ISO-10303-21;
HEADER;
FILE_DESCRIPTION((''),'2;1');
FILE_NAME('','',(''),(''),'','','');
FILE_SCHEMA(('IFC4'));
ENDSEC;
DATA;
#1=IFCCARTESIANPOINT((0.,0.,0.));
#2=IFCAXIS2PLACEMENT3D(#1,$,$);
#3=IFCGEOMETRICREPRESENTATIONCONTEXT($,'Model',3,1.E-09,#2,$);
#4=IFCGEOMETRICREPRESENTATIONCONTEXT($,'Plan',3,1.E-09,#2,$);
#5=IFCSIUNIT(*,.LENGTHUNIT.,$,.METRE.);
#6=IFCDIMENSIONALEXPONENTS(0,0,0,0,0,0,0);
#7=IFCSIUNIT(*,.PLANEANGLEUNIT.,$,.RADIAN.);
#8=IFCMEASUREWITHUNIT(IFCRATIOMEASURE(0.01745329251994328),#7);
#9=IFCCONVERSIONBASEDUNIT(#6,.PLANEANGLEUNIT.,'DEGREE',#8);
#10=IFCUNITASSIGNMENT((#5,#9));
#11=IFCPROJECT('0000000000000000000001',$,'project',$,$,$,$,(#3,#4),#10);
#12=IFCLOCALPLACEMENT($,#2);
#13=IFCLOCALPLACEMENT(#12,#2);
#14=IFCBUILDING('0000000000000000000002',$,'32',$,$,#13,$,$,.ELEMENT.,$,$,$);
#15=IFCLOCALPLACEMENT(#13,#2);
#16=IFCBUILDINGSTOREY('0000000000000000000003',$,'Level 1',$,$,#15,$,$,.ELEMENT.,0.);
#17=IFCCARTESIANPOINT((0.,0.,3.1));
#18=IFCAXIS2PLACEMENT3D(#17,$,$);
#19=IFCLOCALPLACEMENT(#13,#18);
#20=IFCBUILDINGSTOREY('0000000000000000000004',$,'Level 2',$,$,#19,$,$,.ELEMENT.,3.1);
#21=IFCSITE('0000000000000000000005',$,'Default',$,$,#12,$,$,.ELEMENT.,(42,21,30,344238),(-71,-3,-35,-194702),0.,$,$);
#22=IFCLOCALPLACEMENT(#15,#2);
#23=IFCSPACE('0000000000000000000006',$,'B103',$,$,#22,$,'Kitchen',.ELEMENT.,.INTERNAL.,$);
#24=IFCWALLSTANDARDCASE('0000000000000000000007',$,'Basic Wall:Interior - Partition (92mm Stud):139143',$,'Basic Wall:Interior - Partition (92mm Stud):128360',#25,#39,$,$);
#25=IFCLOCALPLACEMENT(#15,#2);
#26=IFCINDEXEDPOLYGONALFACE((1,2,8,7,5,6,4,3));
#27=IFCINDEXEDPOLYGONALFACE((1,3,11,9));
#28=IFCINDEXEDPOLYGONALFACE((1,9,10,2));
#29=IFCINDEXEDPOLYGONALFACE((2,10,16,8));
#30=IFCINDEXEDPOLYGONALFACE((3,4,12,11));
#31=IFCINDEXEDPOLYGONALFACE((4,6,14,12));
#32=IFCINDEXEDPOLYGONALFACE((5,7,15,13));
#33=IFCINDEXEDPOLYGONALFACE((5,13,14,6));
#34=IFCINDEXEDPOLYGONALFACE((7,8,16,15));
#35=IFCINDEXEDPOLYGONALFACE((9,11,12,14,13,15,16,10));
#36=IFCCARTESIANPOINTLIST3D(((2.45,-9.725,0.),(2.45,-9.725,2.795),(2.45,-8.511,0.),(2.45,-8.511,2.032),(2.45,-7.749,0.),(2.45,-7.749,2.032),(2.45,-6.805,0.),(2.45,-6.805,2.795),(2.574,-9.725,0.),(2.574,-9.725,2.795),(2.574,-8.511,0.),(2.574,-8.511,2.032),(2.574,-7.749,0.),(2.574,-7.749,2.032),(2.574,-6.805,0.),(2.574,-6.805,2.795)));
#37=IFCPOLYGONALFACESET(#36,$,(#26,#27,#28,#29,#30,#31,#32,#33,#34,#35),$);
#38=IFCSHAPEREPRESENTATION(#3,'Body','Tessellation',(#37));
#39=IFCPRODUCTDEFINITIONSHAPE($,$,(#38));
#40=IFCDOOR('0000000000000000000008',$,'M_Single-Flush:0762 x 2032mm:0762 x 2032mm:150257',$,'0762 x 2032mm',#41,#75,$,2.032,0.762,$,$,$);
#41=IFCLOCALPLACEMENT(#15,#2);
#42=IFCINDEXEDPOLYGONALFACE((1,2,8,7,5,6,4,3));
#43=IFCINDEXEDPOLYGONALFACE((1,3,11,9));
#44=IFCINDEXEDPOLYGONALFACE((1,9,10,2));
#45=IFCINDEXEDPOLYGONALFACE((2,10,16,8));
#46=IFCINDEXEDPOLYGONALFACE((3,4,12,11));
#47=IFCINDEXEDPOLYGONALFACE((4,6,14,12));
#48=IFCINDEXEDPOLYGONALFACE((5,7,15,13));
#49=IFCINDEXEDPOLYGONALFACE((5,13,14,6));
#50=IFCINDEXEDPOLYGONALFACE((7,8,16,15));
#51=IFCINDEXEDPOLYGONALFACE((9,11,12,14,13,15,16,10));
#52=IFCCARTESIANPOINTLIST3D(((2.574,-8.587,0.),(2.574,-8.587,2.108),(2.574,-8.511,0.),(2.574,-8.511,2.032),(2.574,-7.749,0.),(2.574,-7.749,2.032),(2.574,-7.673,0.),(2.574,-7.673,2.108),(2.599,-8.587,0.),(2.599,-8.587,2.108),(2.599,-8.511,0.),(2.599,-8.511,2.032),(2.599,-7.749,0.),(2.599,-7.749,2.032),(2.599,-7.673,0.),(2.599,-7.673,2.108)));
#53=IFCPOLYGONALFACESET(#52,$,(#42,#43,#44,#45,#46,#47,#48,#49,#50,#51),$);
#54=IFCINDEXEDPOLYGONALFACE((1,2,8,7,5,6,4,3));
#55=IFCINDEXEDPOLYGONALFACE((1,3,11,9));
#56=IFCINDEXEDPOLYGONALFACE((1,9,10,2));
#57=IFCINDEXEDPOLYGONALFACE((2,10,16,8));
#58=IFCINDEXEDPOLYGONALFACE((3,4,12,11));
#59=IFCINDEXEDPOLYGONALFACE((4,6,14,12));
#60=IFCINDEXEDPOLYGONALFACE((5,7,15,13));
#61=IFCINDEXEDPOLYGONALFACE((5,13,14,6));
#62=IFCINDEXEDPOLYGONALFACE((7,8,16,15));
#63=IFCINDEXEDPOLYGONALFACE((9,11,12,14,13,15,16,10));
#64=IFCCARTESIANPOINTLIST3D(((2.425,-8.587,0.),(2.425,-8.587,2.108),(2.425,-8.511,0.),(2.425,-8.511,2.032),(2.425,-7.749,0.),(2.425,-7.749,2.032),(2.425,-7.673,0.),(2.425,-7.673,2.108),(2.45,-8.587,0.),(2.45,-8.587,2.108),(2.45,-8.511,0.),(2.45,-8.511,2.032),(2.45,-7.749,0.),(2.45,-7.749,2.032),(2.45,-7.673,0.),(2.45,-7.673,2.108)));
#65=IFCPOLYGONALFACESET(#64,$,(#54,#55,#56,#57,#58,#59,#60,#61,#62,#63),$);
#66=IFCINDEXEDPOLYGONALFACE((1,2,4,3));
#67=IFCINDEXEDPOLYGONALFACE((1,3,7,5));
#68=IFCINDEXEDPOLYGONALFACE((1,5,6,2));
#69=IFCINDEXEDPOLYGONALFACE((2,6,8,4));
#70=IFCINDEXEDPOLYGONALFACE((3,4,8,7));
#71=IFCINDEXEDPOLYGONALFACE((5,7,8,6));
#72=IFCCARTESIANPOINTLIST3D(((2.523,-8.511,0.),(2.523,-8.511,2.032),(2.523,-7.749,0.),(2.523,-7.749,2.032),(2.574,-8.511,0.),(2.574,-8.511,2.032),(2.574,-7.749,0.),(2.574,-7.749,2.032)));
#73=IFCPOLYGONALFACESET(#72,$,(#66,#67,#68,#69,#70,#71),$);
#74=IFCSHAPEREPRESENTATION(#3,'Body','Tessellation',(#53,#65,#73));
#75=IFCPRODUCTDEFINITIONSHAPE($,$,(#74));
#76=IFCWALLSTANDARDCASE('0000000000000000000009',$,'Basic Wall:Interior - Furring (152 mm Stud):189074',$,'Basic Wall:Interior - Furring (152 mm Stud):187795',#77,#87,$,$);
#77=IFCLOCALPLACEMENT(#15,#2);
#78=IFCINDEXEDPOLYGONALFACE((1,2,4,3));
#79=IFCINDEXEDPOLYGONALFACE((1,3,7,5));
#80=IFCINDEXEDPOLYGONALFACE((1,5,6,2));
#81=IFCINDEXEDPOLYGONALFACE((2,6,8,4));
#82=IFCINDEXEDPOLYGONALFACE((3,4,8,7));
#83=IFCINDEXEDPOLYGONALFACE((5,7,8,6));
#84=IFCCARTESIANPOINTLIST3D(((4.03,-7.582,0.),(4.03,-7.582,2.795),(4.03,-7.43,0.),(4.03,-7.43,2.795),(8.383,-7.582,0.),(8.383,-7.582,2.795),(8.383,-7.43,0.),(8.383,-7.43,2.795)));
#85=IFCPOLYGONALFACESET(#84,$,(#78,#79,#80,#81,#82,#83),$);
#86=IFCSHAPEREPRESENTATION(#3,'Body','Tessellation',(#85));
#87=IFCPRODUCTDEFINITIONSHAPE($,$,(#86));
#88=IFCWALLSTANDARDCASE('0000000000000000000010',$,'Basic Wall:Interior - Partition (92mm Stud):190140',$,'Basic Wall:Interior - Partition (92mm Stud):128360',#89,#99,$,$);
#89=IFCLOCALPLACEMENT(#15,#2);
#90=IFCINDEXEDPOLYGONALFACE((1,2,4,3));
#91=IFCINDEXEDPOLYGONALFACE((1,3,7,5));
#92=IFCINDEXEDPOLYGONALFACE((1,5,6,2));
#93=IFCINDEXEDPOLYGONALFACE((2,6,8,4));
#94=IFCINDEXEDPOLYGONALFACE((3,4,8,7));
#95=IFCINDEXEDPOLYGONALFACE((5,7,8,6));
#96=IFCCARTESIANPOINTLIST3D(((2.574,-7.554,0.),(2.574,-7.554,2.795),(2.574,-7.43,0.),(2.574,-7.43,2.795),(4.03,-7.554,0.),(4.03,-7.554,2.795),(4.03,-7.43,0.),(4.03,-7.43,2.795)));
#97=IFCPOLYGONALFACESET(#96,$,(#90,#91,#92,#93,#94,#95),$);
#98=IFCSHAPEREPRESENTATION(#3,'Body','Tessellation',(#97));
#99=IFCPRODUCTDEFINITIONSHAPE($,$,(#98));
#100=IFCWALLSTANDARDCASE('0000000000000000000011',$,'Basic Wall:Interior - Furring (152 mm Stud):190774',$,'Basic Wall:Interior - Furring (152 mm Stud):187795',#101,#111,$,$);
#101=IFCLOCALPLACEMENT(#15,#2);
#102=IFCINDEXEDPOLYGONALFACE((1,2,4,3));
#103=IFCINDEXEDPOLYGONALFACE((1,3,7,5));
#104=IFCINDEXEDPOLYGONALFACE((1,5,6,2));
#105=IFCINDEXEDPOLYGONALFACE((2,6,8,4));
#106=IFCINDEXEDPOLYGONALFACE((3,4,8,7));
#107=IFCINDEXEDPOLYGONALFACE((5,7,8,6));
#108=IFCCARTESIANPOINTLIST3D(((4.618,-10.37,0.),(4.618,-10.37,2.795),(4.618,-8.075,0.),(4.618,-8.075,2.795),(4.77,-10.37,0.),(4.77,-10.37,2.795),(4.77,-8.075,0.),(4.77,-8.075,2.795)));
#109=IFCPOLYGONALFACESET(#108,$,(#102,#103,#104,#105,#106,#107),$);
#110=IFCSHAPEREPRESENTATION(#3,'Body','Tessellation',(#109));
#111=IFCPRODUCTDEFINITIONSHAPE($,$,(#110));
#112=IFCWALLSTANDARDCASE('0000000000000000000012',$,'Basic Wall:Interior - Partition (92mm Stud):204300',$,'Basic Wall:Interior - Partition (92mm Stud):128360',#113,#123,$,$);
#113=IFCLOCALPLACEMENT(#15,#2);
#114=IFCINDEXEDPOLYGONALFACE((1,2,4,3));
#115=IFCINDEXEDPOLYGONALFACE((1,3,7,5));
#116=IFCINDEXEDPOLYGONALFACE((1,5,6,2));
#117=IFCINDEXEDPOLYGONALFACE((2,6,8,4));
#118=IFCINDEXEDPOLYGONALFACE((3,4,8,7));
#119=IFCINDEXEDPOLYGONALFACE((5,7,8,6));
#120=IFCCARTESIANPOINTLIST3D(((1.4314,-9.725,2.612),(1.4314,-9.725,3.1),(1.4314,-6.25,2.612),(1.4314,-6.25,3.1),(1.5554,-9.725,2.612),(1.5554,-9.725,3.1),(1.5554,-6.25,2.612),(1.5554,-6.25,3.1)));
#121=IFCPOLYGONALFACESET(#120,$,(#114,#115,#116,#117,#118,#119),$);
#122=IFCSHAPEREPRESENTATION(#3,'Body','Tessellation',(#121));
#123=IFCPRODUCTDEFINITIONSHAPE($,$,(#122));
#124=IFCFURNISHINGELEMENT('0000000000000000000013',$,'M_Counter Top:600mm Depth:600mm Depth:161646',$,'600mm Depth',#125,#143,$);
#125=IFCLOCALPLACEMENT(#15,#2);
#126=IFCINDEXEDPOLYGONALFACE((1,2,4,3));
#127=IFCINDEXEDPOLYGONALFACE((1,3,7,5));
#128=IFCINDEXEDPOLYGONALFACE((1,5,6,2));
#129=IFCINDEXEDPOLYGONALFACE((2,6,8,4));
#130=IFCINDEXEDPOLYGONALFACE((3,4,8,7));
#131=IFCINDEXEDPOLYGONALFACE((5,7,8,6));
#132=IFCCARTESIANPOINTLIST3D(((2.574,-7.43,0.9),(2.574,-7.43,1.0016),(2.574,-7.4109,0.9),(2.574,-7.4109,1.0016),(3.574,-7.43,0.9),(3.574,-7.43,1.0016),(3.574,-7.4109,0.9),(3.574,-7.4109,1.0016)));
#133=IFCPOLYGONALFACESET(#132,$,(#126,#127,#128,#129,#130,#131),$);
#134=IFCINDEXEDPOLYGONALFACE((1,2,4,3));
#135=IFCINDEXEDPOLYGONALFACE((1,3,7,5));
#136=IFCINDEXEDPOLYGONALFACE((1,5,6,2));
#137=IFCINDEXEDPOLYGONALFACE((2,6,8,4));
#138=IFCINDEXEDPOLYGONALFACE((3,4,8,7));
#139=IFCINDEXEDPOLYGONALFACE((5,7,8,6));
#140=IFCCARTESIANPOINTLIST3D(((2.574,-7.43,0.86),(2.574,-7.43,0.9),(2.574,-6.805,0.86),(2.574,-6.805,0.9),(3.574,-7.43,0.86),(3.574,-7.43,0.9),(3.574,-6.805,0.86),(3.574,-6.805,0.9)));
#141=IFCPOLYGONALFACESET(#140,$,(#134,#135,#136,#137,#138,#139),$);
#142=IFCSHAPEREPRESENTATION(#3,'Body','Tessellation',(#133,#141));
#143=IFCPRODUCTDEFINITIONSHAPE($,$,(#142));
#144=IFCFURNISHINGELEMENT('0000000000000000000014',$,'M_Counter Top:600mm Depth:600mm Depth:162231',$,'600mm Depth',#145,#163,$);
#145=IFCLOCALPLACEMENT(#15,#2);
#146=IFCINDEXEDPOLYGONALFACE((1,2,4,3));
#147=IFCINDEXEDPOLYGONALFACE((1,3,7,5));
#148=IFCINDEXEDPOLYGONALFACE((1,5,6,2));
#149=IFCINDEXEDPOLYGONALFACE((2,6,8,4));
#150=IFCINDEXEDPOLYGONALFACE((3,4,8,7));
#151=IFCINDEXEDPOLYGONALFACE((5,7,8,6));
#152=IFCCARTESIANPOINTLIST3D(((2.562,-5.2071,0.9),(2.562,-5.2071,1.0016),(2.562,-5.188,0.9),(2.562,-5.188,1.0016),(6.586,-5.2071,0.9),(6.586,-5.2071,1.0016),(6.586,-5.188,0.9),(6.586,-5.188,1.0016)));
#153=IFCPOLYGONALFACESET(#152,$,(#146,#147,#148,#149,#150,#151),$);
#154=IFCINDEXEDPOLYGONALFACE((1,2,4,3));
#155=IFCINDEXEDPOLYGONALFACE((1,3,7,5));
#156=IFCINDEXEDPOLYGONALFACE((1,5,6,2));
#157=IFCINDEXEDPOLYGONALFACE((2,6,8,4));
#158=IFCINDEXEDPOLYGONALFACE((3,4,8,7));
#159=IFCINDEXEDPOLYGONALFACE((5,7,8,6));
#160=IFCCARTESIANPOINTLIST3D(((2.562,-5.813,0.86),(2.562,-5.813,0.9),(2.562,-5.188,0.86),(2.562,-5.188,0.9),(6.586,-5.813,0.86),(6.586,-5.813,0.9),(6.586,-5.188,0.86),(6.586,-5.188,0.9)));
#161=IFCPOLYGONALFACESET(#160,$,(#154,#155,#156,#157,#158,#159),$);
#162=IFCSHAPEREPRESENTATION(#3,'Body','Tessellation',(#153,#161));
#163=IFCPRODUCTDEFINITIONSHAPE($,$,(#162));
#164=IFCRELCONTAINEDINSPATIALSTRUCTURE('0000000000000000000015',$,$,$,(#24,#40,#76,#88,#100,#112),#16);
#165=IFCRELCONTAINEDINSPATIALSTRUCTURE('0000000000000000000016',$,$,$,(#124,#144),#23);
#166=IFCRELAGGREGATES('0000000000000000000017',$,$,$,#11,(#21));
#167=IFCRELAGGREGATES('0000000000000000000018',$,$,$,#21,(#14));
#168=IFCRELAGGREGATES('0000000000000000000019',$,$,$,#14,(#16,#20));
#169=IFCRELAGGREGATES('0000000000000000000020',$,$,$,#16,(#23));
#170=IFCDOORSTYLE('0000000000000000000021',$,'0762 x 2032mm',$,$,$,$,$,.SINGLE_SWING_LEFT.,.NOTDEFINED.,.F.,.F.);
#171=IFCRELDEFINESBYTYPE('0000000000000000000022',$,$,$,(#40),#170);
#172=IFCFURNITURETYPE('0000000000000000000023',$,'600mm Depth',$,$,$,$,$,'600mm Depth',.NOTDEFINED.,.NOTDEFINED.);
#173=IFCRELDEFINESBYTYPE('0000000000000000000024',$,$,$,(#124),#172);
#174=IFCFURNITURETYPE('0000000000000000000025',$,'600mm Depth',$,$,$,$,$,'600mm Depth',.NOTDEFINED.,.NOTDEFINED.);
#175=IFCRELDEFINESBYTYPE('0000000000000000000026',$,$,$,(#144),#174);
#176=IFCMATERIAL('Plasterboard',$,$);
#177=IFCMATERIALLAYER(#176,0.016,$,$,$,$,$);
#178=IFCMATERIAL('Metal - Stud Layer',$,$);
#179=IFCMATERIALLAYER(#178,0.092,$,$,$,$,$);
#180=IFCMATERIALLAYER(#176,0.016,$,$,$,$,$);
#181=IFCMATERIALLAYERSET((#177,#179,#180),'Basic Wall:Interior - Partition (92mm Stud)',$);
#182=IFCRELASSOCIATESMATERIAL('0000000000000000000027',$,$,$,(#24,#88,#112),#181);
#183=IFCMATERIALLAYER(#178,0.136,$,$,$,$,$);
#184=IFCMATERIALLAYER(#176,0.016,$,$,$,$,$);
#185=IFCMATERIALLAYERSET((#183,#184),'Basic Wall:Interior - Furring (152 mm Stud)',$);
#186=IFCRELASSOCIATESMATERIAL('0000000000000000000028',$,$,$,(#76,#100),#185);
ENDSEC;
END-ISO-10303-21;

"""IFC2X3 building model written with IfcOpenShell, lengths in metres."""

from ifc_helpers import new_model, entity, si_unit, converted_unit, frame, frame_2d, origin, origin_2d_with_axis, place, context, project, spatial, polyline, rectangle, outline, extrude, clip, bounded_halfspace, source, transform, mapped, material, layer, layer_set, layer_usage, type_object, type_shapes, element, fill, save


model = new_model("IFC2X3")

# Units and contexts
model_context = context("Model", 3, precision=1e-09, world=origin())
plan_context = context("Plan", 3, precision=1e-09, world=origin())
ifc_project = project(units=[si_unit("LENGTHUNIT", "METRE"), converted_unit("PLANEANGLEUNIT", "DEGREE", entity("IfcRatioMeasure", 0.01745329251994328), si_unit("PLANEANGLEUNIT", "RADIAN"), dimensions=[0, 0, 0, 0, 0, 0, 0])], contexts=[model_context, plan_context])

# Site, building, storey
site_placement = place(None, origin())
site = spatial("IfcSite", under=ifc_project, at=site_placement, Name="Default", CompositionType="ELEMENT", RefLatitude=(42, 21, 30, 344238), RefLongitude=(-71, -3, -35, -194702), RefElevation=0.0)
building_placement = place(site_placement, origin())
building = spatial("IfcBuilding", under=site, at=building_placement, Name="32", CompositionType="ELEMENT")
storey_1_placement = place(building_placement, origin())
storey_1 = spatial("IfcBuildingStorey", under=building, at=storey_1_placement, Name="Level 1", CompositionType="ELEMENT", Elevation=0.0)

# Shared definitions
ifc_material_1 = material(Name="Metal - Stud Layer")
ifc_material_2 = material(Name="Plasterboard")

# Shared definitions
ifc_layer_1 = layer(ifc_material_2, 0.016)
ifc_layer_2 = layer(ifc_material_1, 0.092)
ifc_layer_3 = layer(ifc_material_2, 0.016)
ifc_layer_set_1 = layer_set([ifc_layer_1, ifc_layer_2, ifc_layer_3], Name="Basic Wall:Interior - Partition (92mm Stud)")

# Wall, opening, door
ifc_layer_usage_1 = layer_usage(ifc_layer_set_1, "AXIS2", "NEGATIVE", 0.062)
wall_1_placement = place(storey_1_placement, frame((2.512, -6.805, 0.0), z_axis=(0.0, 0.0, 1.0), x_axis=(0.0, -1.0, 0.0)))
wall_1 = element("IfcWallStandardCase", 1, at=wall_1_placement, inside=storey_1, material=ifc_layer_usage_1, Name="Basic Wall:Interior - Partition (92mm Stud):139143", ObjectType="Basic Wall:Interior - Partition (92mm Stud):128360", context=model_context, shape_type="SweptSolid", body=[
    extrude(rectangle(XDim=2.92, YDim=0.124, at=frame_2d((1.46, 0.0), x_axis=(-1.0, 0.0))), origin(), (0.0, 0.0, 1.0), 2.795),
])
opening_1_placement = place(wall_1_placement, frame((0.944, -0.062, 0.0)))
opening_1 = element("IfcOpeningElement", 2, at=opening_1_placement, cuts=wall_1, ObjectType="Opening", context=model_context, shape_type="SweptSolid", body=[
    extrude(rectangle(XDim=0.762, YDim=2.032, at=frame_2d((1.016, 0.381), x_axis=(0.0, -1.0))), frame((0.0, 0.0, 0.0), z_axis=(0.0, 1.0, 0.0), x_axis=(0.0, 0.0, 1.0)), (0.0, 0.0, 1.0), 0.124),
])
door_style_1 = type_object("IfcDoorStyle", Name="0762 x 2032mm", ConstructionType="NOTDEFINED", OperationType="SINGLE_SWING_LEFT", ParameterTakesPrecedence=False, Sizeable=False)
shared_shape_1 = source(origin(), model_context, "Body", "SweptSolid", [
    extrude(outline(polyline([(-0.457, -1.073), (0.457, -1.073), (0.457, 1.035), (0.381, 1.035), (0.381, -0.997), (-0.381, -0.997), (-0.381, 1.035), (-0.457, 1.035), (-0.457, -1.073)])), frame((0.381, 0.149, 1.035), z_axis=(0.0, -1.0, 0.0), x_axis=(-1.0, 0.0, 0.0)), (0.0, 0.0, 1.0), 0.025),
    extrude(outline(polyline([(-1.073, -0.457), (1.035, -0.457), (1.035, -0.381), (-0.997, -0.381), (-0.997, 0.381), (1.035, 0.381), (1.035, 0.457), (-1.073, 0.457), (-1.073, -0.457)])), frame((0.381, 0.0, 1.035), z_axis=(0.0, -1.0, 0.0), x_axis=(0.0, 0.0, -1.0)), (0.0, 0.0, 1.0), 0.025),
    extrude(rectangle(XDim=0.762, YDim=0.051, at=origin_2d_with_axis()), frame((0.381, 0.0985, 0.0)), (0.0, 0.0, 1.0), 2.032),
])
type_shapes(door_style_1, [shared_shape_1])
door_1_placement = place(opening_1_placement, origin())
door_1 = element("IfcDoor", 3, at=door_1_placement, inside=storey_1, type_object=door_style_1, Name="M_Single-Flush:0762 x 2032mm:0762 x 2032mm:150257", ObjectType="0762 x 2032mm", OverallHeight=2.032, OverallWidth=0.762, context=model_context, shape_type="MappedRepresentation", body=[
    mapped(shared_shape_1, transform((0.0, 0.0, 0.0), scale=1.0)),
])
fill(opening_1, door_1)

# Shared definitions
storey_2_placement = place(building_placement, frame((0.0, 0.0, 3.1)))
storey_2 = spatial("IfcBuildingStorey", under=building, at=storey_2_placement, Name="Level 2", CompositionType="ELEMENT", Elevation=3.1)

# Walls
ifc_layer_4 = layer(ifc_material_1, 0.136)
ifc_layer_5 = layer(ifc_material_2, 0.016)
ifc_layer_set_2 = layer_set([ifc_layer_4, ifc_layer_5], Name="Basic Wall:Interior - Furring (152 mm Stud)")
ifc_layer_usage_2 = layer_usage(ifc_layer_set_2, "AXIS2", "NEGATIVE", 0.076)
wall_2_placement = place(storey_1_placement, frame((8.383, -7.506, 0.0), z_axis=(0.0, 0.0, 1.0), x_axis=(-1.0, 0.0, 0.0)))
element("IfcWallStandardCase", 4, at=wall_2_placement, inside=storey_1, material=ifc_layer_usage_2, Name="Basic Wall:Interior - Furring (152 mm Stud):189074", ObjectType="Basic Wall:Interior - Furring (152 mm Stud):187795", context=model_context, shape_type="Clipping", body=[
    clip(extrude(rectangle(XDim=4.353, YDim=0.152, at=frame_2d((2.1765, 0.0), x_axis=(-1.0, 0.0))), origin(), (0.0, 0.0, 1.0), 2.795), bounded_halfspace(frame((0.0, -0.076, 2.795), z_axis=(0.0, 0.0, -1.0), x_axis=(0.0, 1.0, 0.0)), True, frame((0.0, -0.076, 2.795)), polyline([(0.0, 0.0), (3.708, 0.0), (3.708, 0.152), (0.0, 0.152), (0.0, 0.0)]))),
])
ifc_layer_usage_3 = layer_usage(ifc_layer_set_1, "AXIS2", "NEGATIVE", 0.062)
wall_3_placement = place(storey_1_placement, frame((4.03, -7.492, 0.0), z_axis=(0.0, 0.0, 1.0), x_axis=(-1.0, 0.0, 0.0)))
element("IfcWallStandardCase", 5, at=wall_3_placement, inside=storey_1, material=ifc_layer_usage_3, Name="Basic Wall:Interior - Partition (92mm Stud):190140", ObjectType="Basic Wall:Interior - Partition (92mm Stud):128360", context=model_context, shape_type="SweptSolid", body=[
    extrude(rectangle(XDim=1.456, YDim=0.124, at=frame_2d((0.728, 0.0), x_axis=(-1.0, 0.0))), origin(), (0.0, 0.0, 1.0), 2.795),
])
ifc_layer_usage_4 = layer_usage(ifc_layer_set_2, "AXIS2", "POSITIVE", -0.076)
wall_4_placement = place(storey_1_placement, frame((4.694, -8.075, 0.0), z_axis=(0.0, 0.0, 1.0), x_axis=(0.0, -1.0, 0.0)))
element("IfcWallStandardCase", 6, at=wall_4_placement, inside=storey_1, material=ifc_layer_usage_4, Name="Basic Wall:Interior - Furring (152 mm Stud):190774", ObjectType="Basic Wall:Interior - Furring (152 mm Stud):187795", context=model_context, shape_type="SweptSolid", body=[
    extrude(rectangle(XDim=2.295, YDim=0.152, at=frame_2d((1.1475, 0.0), x_axis=(-1.0, 0.0))), origin(), (0.0, 0.0, 1.0), 2.795),
])
ifc_layer_usage_5 = layer_usage(ifc_layer_set_1, "AXIS2", "NEGATIVE", 0.062)
wall_5_placement = place(storey_1_placement, frame((1.4934, -6.25, 2.612), z_axis=(0.0, 0.0, 1.0), x_axis=(0.0, -1.0, 0.0)))
element("IfcWallStandardCase", 7, at=wall_5_placement, inside=storey_1, material=ifc_layer_usage_5, Name="Basic Wall:Interior - Partition (92mm Stud):204300", ObjectType="Basic Wall:Interior - Partition (92mm Stud):128360", context=model_context, shape_type="SweptSolid", body=[
    extrude(rectangle(XDim=3.475, YDim=0.124, at=frame_2d((1.7375, 0.0), x_axis=(-1.0, 0.0))), origin(), (0.0, 0.0, 1.0), 0.488),
])

# Shared definitions
space_1_placement = place(storey_1_placement, origin())
space_1 = spatial("IfcSpace", under=storey_1, at=space_1_placement, Name="B103", LongName="Kitchen", CompositionType="ELEMENT", InteriorOrExteriorSpace="INTERNAL")

# Furnishing elements
furniture_type_1 = type_object("IfcFurnitureType", Name="600mm Depth", ElementType="600mm Depth", AssemblyPlace="NOTDEFINED")
shared_shape_2 = source(origin(), model_context, "Body", "SweptSolid", [
    extrude(rectangle(XDim=0.0191, YDim=1.0, at=origin_2d_with_axis()), frame((-0.7005, -0.0095, 0.9), z_axis=(0.0, 0.0, 1.0), x_axis=(0.0, -1.0, 0.0)), (0.0, 0.0, 1.0), 0.1016),
    extrude(rectangle(XDim=1.0, YDim=0.625, at=origin_2d_with_axis()), frame((-0.7005, -0.3125, 0.86), z_axis=(0.0, 0.0, 1.0), x_axis=(-1.0, 0.0, 0.0)), (0.0, 0.0, 1.0), 0.04),
])
type_shapes(furniture_type_1, [shared_shape_2])
furnishing_1_placement = place(space_1_placement, frame((2.3735, -7.43, 0.0), z_axis=(0.0, 0.0, 1.0), x_axis=(-1.0, 0.0, 0.0)))
element("IfcFurnishingElement", 8, at=furnishing_1_placement, inside=space_1, type_object=furniture_type_1, Name="M_Counter Top:600mm Depth:600mm Depth:161646", ObjectType="600mm Depth", context=model_context, shape_type="MappedRepresentation", body=[
    mapped(shared_shape_2, transform((0.0, 0.0, 0.0), scale=1.0)),
])
furniture_type_2 = type_object("IfcFurnitureType", Name="600mm Depth", ElementType="600mm Depth", AssemblyPlace="NOTDEFINED")
shared_shape_3 = source(origin(), model_context, "Body", "SweptSolid", [
    extrude(rectangle(XDim=0.0191, YDim=4.024, at=origin_2d_with_axis()), frame((0.8115, -0.0095, 0.9), z_axis=(0.0, 0.0, 1.0), x_axis=(0.0, -1.0, 0.0)), (0.0, 0.0, 1.0), 0.1016),
    extrude(rectangle(XDim=4.024, YDim=0.625, at=origin_2d_with_axis()), frame((0.8115, -0.3125, 0.86), z_axis=(0.0, 0.0, 1.0), x_axis=(-1.0, 0.0, 0.0)), (0.0, 0.0, 1.0), 0.04),
])
type_shapes(furniture_type_2, [shared_shape_3])
furnishing_2_placement = place(space_1_placement, frame((3.7625, -5.188, 0.0)))
element("IfcFurnishingElement", 9, at=furnishing_2_placement, inside=space_1, type_object=furniture_type_2, Name="M_Counter Top:600mm Depth:600mm Depth:162231", ObjectType="600mm Depth", context=model_context, shape_type="MappedRepresentation", body=[
    mapped(shared_shape_3, transform((0.0, 0.0, 0.0), scale=1.0)),
])

save(model, "model.ifc")
